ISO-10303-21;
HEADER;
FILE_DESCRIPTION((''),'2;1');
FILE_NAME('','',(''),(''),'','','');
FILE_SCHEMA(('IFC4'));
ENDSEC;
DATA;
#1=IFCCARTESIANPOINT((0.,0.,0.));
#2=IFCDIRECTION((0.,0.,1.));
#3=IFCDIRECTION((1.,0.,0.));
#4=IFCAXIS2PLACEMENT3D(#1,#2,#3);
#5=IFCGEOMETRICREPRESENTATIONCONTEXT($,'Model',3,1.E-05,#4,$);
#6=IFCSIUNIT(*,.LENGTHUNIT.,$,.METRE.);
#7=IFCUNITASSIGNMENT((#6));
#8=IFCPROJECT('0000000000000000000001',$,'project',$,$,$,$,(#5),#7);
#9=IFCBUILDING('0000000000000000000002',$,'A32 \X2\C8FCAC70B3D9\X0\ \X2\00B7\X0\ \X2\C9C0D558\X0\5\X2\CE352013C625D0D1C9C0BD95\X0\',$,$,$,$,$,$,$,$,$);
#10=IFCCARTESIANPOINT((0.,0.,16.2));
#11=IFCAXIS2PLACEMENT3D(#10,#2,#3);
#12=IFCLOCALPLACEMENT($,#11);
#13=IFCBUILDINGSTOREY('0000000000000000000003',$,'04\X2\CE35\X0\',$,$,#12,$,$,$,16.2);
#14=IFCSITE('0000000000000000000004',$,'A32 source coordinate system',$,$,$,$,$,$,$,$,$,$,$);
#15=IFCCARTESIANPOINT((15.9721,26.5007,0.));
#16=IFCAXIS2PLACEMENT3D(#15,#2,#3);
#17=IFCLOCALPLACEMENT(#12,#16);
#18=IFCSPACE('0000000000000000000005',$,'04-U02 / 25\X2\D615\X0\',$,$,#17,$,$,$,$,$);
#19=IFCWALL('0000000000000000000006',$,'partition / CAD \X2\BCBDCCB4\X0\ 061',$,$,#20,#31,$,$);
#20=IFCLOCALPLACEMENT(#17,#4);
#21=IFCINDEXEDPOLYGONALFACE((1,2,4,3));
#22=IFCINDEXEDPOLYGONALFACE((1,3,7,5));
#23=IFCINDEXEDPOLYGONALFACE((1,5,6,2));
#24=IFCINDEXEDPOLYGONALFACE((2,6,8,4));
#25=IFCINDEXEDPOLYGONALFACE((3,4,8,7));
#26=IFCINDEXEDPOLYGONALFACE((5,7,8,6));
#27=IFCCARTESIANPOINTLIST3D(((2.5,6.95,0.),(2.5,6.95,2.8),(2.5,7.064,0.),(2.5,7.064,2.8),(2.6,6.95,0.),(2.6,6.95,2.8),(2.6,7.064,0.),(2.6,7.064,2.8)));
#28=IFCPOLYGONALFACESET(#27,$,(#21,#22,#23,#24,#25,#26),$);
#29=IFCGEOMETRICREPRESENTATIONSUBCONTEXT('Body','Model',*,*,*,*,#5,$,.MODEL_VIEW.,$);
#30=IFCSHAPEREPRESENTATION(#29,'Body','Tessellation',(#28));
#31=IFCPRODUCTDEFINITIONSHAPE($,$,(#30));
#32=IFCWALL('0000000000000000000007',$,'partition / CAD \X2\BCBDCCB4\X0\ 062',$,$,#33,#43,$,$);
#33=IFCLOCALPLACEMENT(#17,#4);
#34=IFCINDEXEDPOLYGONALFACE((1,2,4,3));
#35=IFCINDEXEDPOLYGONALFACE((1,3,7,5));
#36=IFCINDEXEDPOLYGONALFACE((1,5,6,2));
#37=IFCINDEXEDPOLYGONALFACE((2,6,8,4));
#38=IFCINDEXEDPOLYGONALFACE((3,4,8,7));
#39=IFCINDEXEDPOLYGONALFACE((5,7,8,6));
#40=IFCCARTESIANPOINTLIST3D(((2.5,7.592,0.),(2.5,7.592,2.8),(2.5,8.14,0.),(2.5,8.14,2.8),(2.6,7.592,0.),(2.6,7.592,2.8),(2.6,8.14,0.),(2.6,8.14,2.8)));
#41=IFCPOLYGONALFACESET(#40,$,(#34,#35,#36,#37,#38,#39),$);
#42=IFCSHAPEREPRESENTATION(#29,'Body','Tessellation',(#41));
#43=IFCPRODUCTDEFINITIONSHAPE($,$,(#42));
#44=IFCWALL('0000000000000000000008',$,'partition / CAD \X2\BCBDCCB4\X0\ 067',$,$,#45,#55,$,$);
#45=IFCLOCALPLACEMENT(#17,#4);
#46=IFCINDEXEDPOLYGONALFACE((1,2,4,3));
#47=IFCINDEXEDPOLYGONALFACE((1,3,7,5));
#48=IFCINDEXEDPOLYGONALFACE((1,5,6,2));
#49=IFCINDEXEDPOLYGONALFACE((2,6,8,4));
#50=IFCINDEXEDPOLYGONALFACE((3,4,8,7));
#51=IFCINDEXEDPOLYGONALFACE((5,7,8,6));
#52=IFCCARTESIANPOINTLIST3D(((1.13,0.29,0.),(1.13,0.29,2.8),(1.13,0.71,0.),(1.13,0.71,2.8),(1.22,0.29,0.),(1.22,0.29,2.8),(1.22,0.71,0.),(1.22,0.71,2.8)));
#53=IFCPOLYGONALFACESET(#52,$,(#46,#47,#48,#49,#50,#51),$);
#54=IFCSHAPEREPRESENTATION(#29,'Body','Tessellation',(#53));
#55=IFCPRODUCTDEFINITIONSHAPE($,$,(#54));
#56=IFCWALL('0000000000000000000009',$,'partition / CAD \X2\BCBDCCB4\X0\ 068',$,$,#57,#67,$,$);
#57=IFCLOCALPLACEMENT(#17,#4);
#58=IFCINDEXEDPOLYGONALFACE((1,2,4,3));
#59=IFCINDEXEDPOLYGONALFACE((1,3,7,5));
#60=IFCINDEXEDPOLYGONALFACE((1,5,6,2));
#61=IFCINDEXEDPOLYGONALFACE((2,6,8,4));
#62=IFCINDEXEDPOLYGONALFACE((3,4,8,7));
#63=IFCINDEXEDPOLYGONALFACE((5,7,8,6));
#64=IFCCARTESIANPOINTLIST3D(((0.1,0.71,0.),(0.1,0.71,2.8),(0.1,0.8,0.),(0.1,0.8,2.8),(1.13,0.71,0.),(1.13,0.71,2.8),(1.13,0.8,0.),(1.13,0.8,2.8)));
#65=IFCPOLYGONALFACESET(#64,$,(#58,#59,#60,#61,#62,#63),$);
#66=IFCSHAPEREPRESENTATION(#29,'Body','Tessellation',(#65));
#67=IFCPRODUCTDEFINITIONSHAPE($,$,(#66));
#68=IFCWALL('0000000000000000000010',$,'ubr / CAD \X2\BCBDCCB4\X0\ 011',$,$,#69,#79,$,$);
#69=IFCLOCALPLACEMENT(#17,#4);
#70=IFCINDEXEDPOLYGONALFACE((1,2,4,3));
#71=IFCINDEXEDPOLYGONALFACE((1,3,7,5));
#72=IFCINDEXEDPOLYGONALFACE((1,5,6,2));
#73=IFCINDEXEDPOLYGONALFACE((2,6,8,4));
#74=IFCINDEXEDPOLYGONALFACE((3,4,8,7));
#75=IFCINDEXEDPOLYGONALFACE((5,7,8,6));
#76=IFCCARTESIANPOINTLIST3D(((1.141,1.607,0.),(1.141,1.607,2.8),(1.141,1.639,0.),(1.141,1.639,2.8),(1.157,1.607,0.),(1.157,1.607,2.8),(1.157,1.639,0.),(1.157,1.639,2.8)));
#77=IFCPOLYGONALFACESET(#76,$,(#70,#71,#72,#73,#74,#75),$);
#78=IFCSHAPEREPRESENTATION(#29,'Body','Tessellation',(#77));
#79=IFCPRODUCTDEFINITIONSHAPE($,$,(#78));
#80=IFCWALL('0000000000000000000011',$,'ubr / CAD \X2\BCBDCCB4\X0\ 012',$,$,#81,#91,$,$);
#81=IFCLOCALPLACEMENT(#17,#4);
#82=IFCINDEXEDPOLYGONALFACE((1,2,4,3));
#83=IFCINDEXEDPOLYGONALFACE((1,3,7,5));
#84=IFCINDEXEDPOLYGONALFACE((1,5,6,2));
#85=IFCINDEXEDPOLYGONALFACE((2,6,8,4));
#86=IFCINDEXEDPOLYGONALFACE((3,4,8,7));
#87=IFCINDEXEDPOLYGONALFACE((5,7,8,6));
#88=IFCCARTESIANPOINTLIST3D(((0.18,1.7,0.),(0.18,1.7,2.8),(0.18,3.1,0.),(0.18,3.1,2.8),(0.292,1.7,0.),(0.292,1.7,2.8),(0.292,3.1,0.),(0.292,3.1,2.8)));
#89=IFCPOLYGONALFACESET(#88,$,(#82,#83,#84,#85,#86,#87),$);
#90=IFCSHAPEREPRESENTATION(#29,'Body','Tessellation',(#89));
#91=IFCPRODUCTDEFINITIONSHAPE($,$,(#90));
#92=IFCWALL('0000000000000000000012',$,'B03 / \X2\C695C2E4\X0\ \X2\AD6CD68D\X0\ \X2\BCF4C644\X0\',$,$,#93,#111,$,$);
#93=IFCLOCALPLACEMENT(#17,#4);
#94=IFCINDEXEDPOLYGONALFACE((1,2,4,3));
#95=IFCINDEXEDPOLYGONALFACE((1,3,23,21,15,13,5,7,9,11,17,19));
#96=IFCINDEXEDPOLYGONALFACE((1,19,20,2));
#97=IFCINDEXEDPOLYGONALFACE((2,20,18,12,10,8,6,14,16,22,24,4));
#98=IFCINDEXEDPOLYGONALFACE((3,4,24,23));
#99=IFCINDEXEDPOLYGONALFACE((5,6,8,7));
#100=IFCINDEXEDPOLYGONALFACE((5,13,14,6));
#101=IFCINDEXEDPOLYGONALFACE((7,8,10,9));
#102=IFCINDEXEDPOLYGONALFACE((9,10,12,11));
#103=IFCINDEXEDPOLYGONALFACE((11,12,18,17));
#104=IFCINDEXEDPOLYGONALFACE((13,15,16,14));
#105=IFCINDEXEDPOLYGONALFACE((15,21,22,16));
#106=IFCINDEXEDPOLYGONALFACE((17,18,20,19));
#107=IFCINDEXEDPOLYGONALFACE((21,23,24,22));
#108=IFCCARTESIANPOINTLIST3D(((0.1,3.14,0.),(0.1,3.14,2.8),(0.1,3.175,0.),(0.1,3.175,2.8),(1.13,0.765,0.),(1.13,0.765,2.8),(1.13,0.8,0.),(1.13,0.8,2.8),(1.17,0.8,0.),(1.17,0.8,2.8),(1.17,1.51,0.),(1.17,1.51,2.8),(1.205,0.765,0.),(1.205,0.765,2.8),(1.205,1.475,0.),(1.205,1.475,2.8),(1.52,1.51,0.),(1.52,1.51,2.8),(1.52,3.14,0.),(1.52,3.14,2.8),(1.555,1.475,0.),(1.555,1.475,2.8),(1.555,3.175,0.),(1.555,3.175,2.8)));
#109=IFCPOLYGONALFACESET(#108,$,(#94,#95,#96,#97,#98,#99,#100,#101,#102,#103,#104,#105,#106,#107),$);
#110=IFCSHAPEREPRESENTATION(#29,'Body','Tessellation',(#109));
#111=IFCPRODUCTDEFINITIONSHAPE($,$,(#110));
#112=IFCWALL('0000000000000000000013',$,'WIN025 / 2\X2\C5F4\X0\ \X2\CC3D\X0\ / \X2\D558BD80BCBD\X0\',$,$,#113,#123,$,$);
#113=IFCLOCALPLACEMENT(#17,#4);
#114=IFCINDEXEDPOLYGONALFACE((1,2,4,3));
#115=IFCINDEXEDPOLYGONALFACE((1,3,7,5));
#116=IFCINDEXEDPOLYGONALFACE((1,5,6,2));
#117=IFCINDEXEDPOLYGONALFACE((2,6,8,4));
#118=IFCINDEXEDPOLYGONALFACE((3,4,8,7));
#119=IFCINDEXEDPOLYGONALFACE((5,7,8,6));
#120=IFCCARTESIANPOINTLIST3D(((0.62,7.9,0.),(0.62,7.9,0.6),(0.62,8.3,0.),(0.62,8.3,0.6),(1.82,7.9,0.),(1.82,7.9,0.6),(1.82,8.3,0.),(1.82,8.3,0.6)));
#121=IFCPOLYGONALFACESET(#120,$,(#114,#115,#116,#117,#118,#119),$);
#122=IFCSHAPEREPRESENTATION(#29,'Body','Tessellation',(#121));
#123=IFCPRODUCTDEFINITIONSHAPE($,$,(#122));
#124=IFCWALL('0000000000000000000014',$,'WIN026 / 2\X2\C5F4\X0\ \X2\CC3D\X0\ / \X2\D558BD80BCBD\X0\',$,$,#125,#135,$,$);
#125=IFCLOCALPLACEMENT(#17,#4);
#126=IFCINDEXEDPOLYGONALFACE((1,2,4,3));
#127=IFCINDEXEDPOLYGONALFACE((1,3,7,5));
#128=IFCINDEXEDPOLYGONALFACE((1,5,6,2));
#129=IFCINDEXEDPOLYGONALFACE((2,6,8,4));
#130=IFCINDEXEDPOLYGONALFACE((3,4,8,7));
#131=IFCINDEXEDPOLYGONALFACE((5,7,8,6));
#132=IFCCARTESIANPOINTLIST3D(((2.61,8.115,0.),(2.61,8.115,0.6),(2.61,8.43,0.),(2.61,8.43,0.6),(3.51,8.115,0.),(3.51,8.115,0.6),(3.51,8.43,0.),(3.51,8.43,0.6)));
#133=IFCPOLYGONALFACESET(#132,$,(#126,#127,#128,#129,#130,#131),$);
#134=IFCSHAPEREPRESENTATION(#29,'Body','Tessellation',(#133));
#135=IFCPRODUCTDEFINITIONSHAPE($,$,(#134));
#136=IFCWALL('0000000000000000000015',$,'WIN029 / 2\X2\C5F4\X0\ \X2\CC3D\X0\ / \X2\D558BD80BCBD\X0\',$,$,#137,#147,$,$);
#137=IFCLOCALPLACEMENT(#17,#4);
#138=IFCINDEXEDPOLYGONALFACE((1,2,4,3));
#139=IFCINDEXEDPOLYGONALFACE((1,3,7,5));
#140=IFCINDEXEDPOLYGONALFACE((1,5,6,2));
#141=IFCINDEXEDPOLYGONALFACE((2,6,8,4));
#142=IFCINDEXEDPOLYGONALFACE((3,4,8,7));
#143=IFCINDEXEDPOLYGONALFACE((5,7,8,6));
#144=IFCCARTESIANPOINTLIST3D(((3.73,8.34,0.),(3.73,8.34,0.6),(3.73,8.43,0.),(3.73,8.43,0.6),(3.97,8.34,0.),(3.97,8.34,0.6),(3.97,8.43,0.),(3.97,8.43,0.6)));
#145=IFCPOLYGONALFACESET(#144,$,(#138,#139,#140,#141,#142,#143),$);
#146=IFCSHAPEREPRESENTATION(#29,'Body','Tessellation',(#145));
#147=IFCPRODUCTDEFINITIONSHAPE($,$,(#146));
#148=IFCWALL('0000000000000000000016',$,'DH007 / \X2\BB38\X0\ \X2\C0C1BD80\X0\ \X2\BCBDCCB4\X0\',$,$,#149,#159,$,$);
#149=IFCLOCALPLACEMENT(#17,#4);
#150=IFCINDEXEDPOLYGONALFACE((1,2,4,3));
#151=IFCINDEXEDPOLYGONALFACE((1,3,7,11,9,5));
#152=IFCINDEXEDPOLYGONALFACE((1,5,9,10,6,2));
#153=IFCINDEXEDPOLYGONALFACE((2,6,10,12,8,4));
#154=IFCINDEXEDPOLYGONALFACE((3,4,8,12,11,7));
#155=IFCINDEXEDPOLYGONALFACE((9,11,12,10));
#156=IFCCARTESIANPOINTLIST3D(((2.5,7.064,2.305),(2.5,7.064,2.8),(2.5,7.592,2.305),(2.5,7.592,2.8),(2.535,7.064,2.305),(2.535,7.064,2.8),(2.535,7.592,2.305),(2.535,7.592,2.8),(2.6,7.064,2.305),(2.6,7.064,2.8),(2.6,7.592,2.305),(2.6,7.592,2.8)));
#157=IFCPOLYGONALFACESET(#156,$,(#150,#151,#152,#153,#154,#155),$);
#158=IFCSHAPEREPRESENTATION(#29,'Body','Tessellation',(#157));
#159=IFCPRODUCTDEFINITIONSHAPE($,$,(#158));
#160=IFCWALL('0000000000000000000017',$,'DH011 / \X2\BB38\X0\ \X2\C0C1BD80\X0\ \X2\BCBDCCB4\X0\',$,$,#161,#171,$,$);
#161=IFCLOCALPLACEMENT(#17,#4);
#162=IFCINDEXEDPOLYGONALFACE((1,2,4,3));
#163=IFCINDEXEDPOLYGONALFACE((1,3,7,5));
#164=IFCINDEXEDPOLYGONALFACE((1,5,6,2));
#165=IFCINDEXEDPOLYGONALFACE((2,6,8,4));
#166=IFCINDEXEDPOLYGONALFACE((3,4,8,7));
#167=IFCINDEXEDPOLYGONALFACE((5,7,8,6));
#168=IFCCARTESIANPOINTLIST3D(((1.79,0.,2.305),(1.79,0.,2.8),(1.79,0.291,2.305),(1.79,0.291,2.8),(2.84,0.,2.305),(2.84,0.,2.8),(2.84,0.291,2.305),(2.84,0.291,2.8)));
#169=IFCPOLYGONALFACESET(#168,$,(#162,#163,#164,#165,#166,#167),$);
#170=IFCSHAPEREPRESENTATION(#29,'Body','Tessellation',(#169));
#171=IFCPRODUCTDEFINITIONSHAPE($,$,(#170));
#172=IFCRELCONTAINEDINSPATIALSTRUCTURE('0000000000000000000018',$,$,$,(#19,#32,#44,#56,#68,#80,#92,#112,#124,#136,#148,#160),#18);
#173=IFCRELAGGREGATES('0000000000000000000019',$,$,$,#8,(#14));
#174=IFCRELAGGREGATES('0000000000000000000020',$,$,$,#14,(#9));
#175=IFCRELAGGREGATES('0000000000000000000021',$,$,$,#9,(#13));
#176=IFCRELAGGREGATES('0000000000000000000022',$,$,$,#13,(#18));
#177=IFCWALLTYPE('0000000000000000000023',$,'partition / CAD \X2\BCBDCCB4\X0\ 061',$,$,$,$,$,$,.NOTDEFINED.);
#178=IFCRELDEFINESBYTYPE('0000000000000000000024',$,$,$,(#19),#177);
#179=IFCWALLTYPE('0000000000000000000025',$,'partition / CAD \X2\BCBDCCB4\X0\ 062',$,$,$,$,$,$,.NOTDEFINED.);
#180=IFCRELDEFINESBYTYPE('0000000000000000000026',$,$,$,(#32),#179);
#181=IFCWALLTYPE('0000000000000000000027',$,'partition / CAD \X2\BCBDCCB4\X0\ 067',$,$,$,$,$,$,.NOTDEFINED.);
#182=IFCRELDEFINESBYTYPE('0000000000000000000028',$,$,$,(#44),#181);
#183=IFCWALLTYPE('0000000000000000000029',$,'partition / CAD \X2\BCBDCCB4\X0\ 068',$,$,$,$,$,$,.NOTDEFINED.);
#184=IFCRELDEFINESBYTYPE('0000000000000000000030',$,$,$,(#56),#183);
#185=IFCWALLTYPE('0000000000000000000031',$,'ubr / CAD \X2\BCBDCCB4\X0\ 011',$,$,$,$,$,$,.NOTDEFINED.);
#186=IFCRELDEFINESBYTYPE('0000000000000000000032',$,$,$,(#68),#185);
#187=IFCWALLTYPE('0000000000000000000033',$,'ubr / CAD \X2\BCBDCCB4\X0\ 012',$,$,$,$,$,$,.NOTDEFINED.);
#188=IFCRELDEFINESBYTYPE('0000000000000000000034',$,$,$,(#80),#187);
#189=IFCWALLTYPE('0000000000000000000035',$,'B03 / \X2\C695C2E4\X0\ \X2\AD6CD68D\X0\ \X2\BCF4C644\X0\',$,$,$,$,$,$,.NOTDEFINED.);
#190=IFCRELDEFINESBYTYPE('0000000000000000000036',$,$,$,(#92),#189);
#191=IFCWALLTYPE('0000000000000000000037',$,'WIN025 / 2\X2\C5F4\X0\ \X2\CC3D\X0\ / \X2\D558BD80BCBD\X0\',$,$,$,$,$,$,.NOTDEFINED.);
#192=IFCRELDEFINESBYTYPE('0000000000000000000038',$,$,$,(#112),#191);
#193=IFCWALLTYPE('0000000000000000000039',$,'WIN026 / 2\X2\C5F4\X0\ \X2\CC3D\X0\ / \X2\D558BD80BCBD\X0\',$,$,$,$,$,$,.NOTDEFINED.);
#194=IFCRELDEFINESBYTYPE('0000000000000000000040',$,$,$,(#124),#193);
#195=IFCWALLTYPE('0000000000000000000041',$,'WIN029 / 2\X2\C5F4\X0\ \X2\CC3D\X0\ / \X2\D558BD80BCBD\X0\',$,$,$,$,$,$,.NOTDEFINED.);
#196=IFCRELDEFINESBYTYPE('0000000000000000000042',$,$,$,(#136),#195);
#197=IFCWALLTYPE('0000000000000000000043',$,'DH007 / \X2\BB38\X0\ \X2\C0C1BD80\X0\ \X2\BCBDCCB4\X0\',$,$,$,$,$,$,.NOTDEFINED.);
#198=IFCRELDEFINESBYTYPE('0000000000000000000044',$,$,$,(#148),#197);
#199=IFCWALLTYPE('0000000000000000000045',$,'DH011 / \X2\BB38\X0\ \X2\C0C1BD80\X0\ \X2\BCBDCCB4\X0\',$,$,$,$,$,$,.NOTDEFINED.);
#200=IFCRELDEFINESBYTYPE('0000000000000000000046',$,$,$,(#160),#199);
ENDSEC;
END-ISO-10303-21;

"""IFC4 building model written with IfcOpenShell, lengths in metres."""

from ifc_helpers import new_model, si_unit, frame, origin, origin_with_axes, place, context, subcontext, project, spatial, polyline, outline, extrude, source, transform, mapped, type_object, type_shapes, element, save


model = new_model("IFC4")

# Units and contexts
model_context = context("Model", 3, precision=1e-05, world=origin_with_axes())
body_context = subcontext(model_context, "Body", "Model", "MODEL_VIEW")
ifc_project = project(units=[si_unit("LENGTHUNIT", "METRE")], contexts=[model_context])

# Site, building, storey, space
site = spatial("IfcSite", under=ifc_project, Name="A32 source coordinate system")
building = spatial("IfcBuilding", under=site, Name="A32 주거동 · 지하5층–옥탑지붕")
storey_placement = place(None, frame((0.0, 0.0, 16.2), z_axis=(0.0, 0.0, 1.0), x_axis=(1.0, 0.0, 0.0)))
storey = spatial("IfcBuildingStorey", under=building, at=storey_placement, Name="04층", Elevation=16.2)
space_1_placement = place(storey_placement, frame((15.9721, 26.5007, 0.0), z_axis=(0.0, 0.0, 1.0), x_axis=(1.0, 0.0, 0.0)))
space_1 = spatial("IfcSpace", under=storey, at=space_1_placement, Name="04-U02 / 25형")

# Walls
wall_type_1 = type_object("IfcWallType", Name="partition / CAD 벽체 061", PredefinedType="NOTDEFINED")
shared_shape_1 = source(origin(), body_context, "Body", "SweptSolid", [
    extrude(outline(polyline([(2.6, 7.064), (2.6, 6.95), (2.5, 6.95), (2.5, 7.064), (2.6, 7.064)])), origin(), (0.0, 0.0, 1.0), 2.8),
])
type_shapes(wall_type_1, [shared_shape_1])
wall_1_placement = place(space_1_placement, origin_with_axes())
element("IfcWall", 1, at=wall_1_placement, inside=space_1, type_object=wall_type_1, Name="partition / CAD 벽체 061", context=body_context, shape_type="MappedRepresentation", body=[
    mapped(shared_shape_1, transform((0.0, 0.0, 0.0), scale=1.0)),
])
wall_type_2 = type_object("IfcWallType", Name="partition / CAD 벽체 062", PredefinedType="NOTDEFINED")
shared_shape_2 = source(origin(), body_context, "Body", "SweptSolid", [
    extrude(outline(polyline([(2.5, 7.592), (2.5, 8.14), (2.6, 8.14), (2.6, 7.592), (2.5, 7.592)])), origin(), (0.0, 0.0, 1.0), 2.8),
])
type_shapes(wall_type_2, [shared_shape_2])
wall_2_placement = place(space_1_placement, origin_with_axes())
element("IfcWall", 2, at=wall_2_placement, inside=space_1, type_object=wall_type_2, Name="partition / CAD 벽체 062", context=body_context, shape_type="MappedRepresentation", body=[
    mapped(shared_shape_2, transform((0.0, 0.0, 0.0), scale=1.0)),
])
wall_type_3 = type_object("IfcWallType", Name="partition / CAD 벽체 067", PredefinedType="NOTDEFINED")
shared_shape_3 = source(origin(), body_context, "Body", "SweptSolid", [
    extrude(outline(polyline([(1.22, 0.71), (1.22, 0.29), (1.13, 0.29), (1.13, 0.71), (1.22, 0.71)])), origin(), (0.0, 0.0, 1.0), 2.8),
])
type_shapes(wall_type_3, [shared_shape_3])
wall_3_placement = place(space_1_placement, origin_with_axes())
element("IfcWall", 3, at=wall_3_placement, inside=space_1, type_object=wall_type_3, Name="partition / CAD 벽체 067", context=body_context, shape_type="MappedRepresentation", body=[
    mapped(shared_shape_3, transform((0.0, 0.0, 0.0), scale=1.0)),
])
wall_type_4 = type_object("IfcWallType", Name="partition / CAD 벽체 068", PredefinedType="NOTDEFINED")
shared_shape_4 = source(origin(), body_context, "Body", "SweptSolid", [
    extrude(outline(polyline([(1.13, 0.8), (1.13, 0.71), (0.1, 0.71), (0.1, 0.8), (1.13, 0.8)])), origin(), (0.0, 0.0, 1.0), 2.8),
])
type_shapes(wall_type_4, [shared_shape_4])
wall_4_placement = place(space_1_placement, origin_with_axes())
element("IfcWall", 4, at=wall_4_placement, inside=space_1, type_object=wall_type_4, Name="partition / CAD 벽체 068", context=body_context, shape_type="MappedRepresentation", body=[
    mapped(shared_shape_4, transform((0.0, 0.0, 0.0), scale=1.0)),
])
wall_type_5 = type_object("IfcWallType", Name="ubr / CAD 벽체 011", PredefinedType="NOTDEFINED")
shared_shape_5 = source(origin(), body_context, "Body", "SweptSolid", [
    extrude(outline(polyline([(1.141, 1.607), (1.141, 1.639), (1.157, 1.639), (1.157, 1.607), (1.141, 1.607)])), origin(), (0.0, 0.0, 1.0), 2.8),
])
type_shapes(wall_type_5, [shared_shape_5])
wall_5_placement = place(space_1_placement, origin_with_axes())
element("IfcWall", 5, at=wall_5_placement, inside=space_1, type_object=wall_type_5, Name="ubr / CAD 벽체 011", context=body_context, shape_type="MappedRepresentation", body=[
    mapped(shared_shape_5, transform((0.0, 0.0, 0.0), scale=1.0)),
])
wall_type_6 = type_object("IfcWallType", Name="ubr / CAD 벽체 012", PredefinedType="NOTDEFINED")
shared_shape_6 = source(origin(), body_context, "Body", "SweptSolid", [
    extrude(outline(polyline([(0.18, 1.7), (0.18, 3.1), (0.292, 3.1), (0.292, 1.7), (0.18, 1.7)])), origin(), (0.0, 0.0, 1.0), 2.8),
])
type_shapes(wall_type_6, [shared_shape_6])
wall_6_placement = place(space_1_placement, origin_with_axes())
element("IfcWall", 6, at=wall_6_placement, inside=space_1, type_object=wall_type_6, Name="ubr / CAD 벽체 012", context=body_context, shape_type="MappedRepresentation", body=[
    mapped(shared_shape_6, transform((0.0, 0.0, 0.0), scale=1.0)),
])
wall_type_7 = type_object("IfcWallType", Name="B03 / 욕실 구획 보완", PredefinedType="NOTDEFINED")
shared_shape_7 = source(origin(), body_context, "Body", "SweptSolid", [
    extrude(outline(polyline([(1.13, 0.765), (1.13, 0.8), (1.17, 0.8), (1.17, 1.51), (1.52, 1.51), (1.52, 3.14), (0.1, 3.14), (0.1, 3.175), (1.555, 3.175), (1.555, 1.475), (1.205, 1.475), (1.205, 0.765), (1.13, 0.765)])), origin(), (0.0, 0.0, 1.0), 2.8),
])
type_shapes(wall_type_7, [shared_shape_7])
wall_7_placement = place(space_1_placement, origin_with_axes())
element("IfcWall", 7, at=wall_7_placement, inside=space_1, type_object=wall_type_7, Name="B03 / 욕실 구획 보완", context=body_context, shape_type="MappedRepresentation", body=[
    mapped(shared_shape_7, transform((0.0, 0.0, 0.0), scale=1.0)),
])
wall_type_8 = type_object("IfcWallType", Name="WIN025 / 2열 창 / 하부벽", PredefinedType="NOTDEFINED")
shared_shape_8 = source(origin(), body_context, "Body", "SweptSolid", [
    extrude(outline(polyline([(1.82, 8.3), (1.82, 7.9), (0.62, 7.9), (0.62, 8.3), (1.82, 8.3)])), origin(), (0.0, 0.0, 1.0), 0.6),
])
type_shapes(wall_type_8, [shared_shape_8])
wall_8_placement = place(space_1_placement, origin_with_axes())
element("IfcWall", 8, at=wall_8_placement, inside=space_1, type_object=wall_type_8, Name="WIN025 / 2열 창 / 하부벽", context=body_context, shape_type="MappedRepresentation", body=[
    mapped(shared_shape_8, transform((0.0, 0.0, 0.0), scale=1.0)),
])
wall_type_9 = type_object("IfcWallType", Name="WIN026 / 2열 창 / 하부벽", PredefinedType="NOTDEFINED")
shared_shape_9 = source(origin(), body_context, "Body", "SweptSolid", [
    extrude(outline(polyline([(3.51, 8.43), (3.51, 8.115), (2.61, 8.115), (2.61, 8.43), (3.51, 8.43)])), origin(), (0.0, 0.0, 1.0), 0.6),
])
type_shapes(wall_type_9, [shared_shape_9])
wall_9_placement = place(space_1_placement, origin_with_axes())
element("IfcWall", 9, at=wall_9_placement, inside=space_1, type_object=wall_type_9, Name="WIN026 / 2열 창 / 하부벽", context=body_context, shape_type="MappedRepresentation", body=[
    mapped(shared_shape_9, transform((0.0, 0.0, 0.0), scale=1.0)),
])
wall_type_10 = type_object("IfcWallType", Name="WIN029 / 2열 창 / 하부벽", PredefinedType="NOTDEFINED")
shared_shape_10 = source(origin(), body_context, "Body", "SweptSolid", [
    extrude(outline(polyline([(3.97, 8.43), (3.97, 8.34), (3.73, 8.34), (3.73, 8.43), (3.97, 8.43)])), origin(), (0.0, 0.0, 1.0), 0.6),
])
type_shapes(wall_type_10, [shared_shape_10])
wall_10_placement = place(space_1_placement, origin_with_axes())
element("IfcWall", 10, at=wall_10_placement, inside=space_1, type_object=wall_type_10, Name="WIN029 / 2열 창 / 하부벽", context=body_context, shape_type="MappedRepresentation", body=[
    mapped(shared_shape_10, transform((0.0, 0.0, 0.0), scale=1.0)),
])
wall_type_11 = type_object("IfcWallType", Name="DH007 / 문 상부 벽체", PredefinedType="NOTDEFINED")
shared_shape_11 = source(origin(), body_context, "Body", "SweptSolid", [
    extrude(outline(polyline([(2.5, 7.592), (2.535, 7.592), (2.6, 7.592), (2.6, 7.064), (2.535, 7.064), (2.5, 7.064), (2.5, 7.592)])), frame((0.0, 0.0, 2.305)), (0.0, 0.0, 1.0), 0.495),
])
type_shapes(wall_type_11, [shared_shape_11])
wall_11_placement = place(space_1_placement, origin_with_axes())
element("IfcWall", 11, at=wall_11_placement, inside=space_1, type_object=wall_type_11, Name="DH007 / 문 상부 벽체", context=body_context, shape_type="MappedRepresentation", body=[
    mapped(shared_shape_11, transform((0.0, 0.0, 0.0), scale=1.0)),
])
wall_type_12 = type_object("IfcWallType", Name="DH011 / 문 상부 벽체", PredefinedType="NOTDEFINED")
shared_shape_12 = source(origin(), body_context, "Body", "SweptSolid", [
    extrude(outline(polyline([(2.84, 0.0), (1.79, 0.0), (1.79, 0.291), (2.84, 0.291), (2.84, 0.0)])), frame((0.0, 0.0, 2.305)), (0.0, 0.0, 1.0), 0.495),
])
type_shapes(wall_type_12, [shared_shape_12])
wall_12_placement = place(space_1_placement, origin_with_axes())
element("IfcWall", 12, at=wall_12_placement, inside=space_1, type_object=wall_type_12, Name="DH011 / 문 상부 벽체", context=body_context, shape_type="MappedRepresentation", body=[
    mapped(shared_shape_12, transform((0.0, 0.0, 0.0), scale=1.0)),
])

save(model, "model.ifc")
